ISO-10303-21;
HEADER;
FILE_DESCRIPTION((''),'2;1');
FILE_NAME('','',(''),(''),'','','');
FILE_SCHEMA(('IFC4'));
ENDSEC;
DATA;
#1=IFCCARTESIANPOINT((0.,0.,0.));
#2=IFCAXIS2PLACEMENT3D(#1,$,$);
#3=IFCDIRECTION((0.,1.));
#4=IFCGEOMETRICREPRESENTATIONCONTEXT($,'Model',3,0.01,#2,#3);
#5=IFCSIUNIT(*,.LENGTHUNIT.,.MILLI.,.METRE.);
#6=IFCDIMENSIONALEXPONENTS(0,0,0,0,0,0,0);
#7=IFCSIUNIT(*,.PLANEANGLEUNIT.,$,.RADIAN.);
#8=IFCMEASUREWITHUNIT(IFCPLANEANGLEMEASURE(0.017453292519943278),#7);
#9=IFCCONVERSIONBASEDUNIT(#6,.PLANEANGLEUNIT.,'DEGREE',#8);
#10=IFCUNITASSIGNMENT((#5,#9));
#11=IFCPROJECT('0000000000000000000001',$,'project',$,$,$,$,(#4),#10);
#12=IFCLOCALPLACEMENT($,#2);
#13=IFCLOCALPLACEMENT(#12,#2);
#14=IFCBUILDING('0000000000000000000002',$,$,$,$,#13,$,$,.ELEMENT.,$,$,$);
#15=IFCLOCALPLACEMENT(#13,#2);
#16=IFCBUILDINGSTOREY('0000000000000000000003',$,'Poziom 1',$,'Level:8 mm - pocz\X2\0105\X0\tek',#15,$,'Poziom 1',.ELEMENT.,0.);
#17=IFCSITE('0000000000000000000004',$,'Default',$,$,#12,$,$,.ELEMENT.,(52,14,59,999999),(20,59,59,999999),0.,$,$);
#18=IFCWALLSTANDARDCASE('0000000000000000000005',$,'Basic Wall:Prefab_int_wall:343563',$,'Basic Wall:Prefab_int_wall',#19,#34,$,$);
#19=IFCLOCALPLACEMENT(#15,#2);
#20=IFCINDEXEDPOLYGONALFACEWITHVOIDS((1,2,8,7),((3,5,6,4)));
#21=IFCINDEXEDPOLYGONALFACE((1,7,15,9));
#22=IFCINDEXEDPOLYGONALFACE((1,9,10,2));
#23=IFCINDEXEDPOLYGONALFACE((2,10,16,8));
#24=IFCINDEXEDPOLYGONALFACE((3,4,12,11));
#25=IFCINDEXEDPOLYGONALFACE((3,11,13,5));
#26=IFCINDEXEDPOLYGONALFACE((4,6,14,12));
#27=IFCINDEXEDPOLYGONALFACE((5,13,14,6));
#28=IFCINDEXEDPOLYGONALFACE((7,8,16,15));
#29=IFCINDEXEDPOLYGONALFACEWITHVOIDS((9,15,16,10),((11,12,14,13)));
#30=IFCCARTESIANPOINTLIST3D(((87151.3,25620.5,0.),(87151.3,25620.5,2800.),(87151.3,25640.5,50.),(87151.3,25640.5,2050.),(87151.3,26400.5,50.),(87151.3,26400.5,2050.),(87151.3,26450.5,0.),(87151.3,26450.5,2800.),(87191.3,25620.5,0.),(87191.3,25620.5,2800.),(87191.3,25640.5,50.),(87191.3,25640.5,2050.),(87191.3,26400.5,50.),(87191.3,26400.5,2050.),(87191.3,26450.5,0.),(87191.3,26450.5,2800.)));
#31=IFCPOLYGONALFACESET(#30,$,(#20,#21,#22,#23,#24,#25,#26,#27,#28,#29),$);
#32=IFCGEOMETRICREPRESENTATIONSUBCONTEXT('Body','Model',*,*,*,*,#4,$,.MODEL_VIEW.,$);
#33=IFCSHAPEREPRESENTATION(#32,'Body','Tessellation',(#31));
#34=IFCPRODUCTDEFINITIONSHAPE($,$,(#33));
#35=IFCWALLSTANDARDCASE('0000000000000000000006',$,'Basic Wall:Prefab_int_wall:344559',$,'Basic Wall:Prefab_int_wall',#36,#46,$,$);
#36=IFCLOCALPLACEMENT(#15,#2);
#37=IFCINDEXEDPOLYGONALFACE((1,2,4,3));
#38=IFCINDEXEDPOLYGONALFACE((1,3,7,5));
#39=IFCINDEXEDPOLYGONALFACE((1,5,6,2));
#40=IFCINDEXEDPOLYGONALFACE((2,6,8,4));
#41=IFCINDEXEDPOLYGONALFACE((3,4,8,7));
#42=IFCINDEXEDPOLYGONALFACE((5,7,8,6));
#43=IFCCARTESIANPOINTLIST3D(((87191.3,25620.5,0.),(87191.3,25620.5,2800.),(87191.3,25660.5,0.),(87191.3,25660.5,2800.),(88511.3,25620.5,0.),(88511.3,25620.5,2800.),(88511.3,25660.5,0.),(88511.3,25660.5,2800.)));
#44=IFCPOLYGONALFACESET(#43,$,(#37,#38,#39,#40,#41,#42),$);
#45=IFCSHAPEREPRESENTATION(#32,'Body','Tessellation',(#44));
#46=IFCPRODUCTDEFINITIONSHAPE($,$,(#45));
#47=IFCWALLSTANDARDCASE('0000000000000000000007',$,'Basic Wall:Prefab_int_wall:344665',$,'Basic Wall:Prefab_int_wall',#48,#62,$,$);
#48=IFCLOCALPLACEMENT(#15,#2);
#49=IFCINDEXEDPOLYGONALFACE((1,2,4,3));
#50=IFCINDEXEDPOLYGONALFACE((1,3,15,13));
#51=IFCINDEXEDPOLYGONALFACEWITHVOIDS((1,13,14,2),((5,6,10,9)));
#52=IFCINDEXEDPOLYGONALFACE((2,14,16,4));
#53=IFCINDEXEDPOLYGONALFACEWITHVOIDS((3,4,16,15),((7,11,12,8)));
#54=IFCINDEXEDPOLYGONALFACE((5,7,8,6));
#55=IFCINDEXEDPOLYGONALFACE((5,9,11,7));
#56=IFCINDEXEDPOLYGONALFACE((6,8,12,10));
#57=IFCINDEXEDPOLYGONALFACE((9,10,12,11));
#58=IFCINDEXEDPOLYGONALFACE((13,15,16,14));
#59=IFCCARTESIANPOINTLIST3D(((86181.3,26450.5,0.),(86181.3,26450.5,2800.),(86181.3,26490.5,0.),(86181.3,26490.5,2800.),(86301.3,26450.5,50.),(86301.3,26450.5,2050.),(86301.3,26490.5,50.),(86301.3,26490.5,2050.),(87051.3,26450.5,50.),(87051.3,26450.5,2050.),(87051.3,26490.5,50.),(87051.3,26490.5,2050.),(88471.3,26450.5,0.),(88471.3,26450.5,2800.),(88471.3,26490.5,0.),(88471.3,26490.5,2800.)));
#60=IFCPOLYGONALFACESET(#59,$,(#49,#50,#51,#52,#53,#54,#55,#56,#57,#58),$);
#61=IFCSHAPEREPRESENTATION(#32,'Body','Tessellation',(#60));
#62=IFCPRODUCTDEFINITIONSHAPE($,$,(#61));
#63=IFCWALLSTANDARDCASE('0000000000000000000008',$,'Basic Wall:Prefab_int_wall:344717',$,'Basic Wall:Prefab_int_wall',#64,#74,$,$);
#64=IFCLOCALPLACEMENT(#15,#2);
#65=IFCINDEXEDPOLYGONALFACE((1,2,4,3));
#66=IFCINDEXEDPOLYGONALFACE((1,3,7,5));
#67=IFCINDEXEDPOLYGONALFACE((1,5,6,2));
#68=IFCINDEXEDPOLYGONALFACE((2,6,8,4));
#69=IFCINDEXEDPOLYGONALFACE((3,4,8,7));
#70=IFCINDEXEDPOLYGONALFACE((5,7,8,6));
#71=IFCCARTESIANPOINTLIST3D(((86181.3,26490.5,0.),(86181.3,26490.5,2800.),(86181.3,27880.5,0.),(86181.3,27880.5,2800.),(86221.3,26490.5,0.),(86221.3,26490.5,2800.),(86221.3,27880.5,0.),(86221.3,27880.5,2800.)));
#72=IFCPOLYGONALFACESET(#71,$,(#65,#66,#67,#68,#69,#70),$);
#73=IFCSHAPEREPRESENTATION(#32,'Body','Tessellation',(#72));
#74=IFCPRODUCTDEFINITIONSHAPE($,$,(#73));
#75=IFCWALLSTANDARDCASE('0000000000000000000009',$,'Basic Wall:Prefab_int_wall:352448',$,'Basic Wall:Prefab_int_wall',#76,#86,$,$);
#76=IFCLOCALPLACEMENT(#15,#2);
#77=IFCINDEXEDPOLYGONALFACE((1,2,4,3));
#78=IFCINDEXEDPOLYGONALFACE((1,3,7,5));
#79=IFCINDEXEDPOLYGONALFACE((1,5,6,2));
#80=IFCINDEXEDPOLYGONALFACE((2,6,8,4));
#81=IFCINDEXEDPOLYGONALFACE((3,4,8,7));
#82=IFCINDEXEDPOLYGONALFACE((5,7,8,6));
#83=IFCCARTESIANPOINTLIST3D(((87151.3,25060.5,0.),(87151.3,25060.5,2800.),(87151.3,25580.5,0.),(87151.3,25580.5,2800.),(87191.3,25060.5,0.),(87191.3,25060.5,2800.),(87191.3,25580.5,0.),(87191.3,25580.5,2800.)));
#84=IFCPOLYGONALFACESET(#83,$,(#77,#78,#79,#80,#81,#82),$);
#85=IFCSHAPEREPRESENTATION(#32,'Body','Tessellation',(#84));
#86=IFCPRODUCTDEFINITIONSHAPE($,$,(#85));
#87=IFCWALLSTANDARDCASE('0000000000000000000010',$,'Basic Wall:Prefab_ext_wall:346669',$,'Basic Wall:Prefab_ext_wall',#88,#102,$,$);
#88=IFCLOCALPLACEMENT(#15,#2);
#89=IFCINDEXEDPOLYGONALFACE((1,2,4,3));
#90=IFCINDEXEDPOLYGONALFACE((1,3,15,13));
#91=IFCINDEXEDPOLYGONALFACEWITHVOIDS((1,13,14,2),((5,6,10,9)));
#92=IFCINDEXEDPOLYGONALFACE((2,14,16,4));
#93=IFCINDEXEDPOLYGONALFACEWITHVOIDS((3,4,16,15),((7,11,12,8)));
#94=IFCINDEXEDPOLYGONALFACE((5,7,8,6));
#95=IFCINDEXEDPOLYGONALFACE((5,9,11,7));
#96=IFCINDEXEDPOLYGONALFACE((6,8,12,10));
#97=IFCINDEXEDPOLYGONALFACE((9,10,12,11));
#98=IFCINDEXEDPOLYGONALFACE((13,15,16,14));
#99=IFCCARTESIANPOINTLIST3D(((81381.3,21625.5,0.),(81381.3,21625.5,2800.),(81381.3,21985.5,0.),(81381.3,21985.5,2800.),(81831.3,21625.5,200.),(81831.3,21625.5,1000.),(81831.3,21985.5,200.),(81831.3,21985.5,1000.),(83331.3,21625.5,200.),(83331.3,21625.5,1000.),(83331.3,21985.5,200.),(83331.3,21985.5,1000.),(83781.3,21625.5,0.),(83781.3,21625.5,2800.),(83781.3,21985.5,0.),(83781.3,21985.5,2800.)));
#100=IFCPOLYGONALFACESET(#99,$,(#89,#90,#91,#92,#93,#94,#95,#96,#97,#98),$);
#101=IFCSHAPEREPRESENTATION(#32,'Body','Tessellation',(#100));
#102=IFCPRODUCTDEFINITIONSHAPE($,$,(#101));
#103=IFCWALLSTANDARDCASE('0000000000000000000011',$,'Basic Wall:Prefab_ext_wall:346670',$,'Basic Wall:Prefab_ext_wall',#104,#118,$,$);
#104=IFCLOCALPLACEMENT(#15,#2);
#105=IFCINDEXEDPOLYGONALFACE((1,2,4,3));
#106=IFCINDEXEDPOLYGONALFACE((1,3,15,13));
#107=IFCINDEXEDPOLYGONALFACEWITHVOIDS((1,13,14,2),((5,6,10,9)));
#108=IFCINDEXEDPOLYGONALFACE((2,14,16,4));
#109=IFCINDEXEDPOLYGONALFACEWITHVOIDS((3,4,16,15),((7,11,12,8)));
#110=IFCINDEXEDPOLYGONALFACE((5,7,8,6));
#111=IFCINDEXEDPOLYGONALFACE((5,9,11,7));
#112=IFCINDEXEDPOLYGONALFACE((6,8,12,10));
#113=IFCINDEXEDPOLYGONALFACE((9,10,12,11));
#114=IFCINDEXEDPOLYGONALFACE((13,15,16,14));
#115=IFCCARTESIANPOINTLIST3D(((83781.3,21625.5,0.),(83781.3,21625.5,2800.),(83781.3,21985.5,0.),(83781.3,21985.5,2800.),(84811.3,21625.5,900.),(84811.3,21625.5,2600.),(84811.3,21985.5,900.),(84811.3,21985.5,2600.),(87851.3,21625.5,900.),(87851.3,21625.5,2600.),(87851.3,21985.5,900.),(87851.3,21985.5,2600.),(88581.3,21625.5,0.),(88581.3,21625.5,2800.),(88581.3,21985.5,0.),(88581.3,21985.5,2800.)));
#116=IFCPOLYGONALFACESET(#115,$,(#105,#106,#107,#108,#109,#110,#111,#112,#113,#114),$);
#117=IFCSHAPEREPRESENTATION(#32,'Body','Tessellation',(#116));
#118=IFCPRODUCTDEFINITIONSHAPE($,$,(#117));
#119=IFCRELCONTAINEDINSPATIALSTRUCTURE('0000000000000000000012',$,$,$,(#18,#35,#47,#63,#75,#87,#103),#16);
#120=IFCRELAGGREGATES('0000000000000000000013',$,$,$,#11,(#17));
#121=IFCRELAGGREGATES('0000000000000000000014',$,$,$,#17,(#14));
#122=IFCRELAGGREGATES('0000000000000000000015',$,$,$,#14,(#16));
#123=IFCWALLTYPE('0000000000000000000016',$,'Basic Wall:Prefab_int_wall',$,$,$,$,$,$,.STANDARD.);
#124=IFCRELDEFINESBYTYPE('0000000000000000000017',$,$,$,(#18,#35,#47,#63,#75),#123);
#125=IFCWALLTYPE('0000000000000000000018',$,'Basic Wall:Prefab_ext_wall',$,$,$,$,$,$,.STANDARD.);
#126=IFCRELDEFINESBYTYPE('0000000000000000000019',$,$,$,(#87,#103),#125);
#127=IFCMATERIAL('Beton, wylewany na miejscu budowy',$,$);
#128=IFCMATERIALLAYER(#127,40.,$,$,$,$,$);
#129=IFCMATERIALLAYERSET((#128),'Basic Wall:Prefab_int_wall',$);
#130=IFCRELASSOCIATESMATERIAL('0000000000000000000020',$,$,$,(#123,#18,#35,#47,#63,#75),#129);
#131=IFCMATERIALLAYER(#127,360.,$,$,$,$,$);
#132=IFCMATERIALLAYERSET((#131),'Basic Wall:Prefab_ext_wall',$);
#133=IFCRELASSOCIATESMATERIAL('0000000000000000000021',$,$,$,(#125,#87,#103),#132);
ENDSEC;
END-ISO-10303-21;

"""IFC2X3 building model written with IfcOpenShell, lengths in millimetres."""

from ifc_helpers import new_model, entity, si_unit, converted_unit, direction, frame, frame_2d, origin, origin_2d_with_axis, place, context, subcontext, project, spatial, rectangle, extrude, material, layer, layer_set, layer_usage, type_object, element, save


model = new_model("IFC2X3")

# Units and contexts
model_context = context("Model", 3, precision=0.01, world=origin(), true_north=direction((0.0, 1.0)))
body_context = subcontext(model_context, "Body", "Model", "MODEL_VIEW")
ifc_project = project(units=[si_unit("LENGTHUNIT", "METRE", prefix="MILLI"), converted_unit("PLANEANGLEUNIT", "DEGREE", entity("IfcPlaneAngleMeasure", 0.017453292519943278), si_unit("PLANEANGLEUNIT", "RADIAN"), dimensions=[0, 0, 0, 0, 0, 0, 0])], contexts=[model_context])

# Site, building, storey
site_placement = place(None, origin())
site = spatial("IfcSite", under=ifc_project, at=site_placement, Name="Default", CompositionType="ELEMENT", RefLatitude=(52, 14, 59, 999999), RefLongitude=(20, 59, 59, 999999), RefElevation=0.0)
building_placement = place(site_placement, origin())
building = spatial("IfcBuilding", under=site, at=building_placement, CompositionType="ELEMENT")
storey_placement = place(building_placement, origin())
storey = spatial("IfcBuildingStorey", under=building, at=storey_placement, Name="Poziom 1", ObjectType="Level:8 mm - początek", LongName="Poziom 1", CompositionType="ELEMENT", Elevation=0.0)

# Shared definitions
ifc_material = material(Name="Beton, wylewany na miejscu budowy")

# Shared definitions
ifc_layer_1 = layer(ifc_material, 40.0)
ifc_layer_set_1 = layer_set([ifc_layer_1], Name="Basic Wall:Prefab_int_wall")
wall_type_1 = type_object("IfcWallType", Name="Basic Wall:Prefab_int_wall", PredefinedType="STANDARD", material=ifc_layer_set_1)

# Wall, opening
ifc_layer_usage_1 = layer_usage(ifc_layer_set_1, "AXIS2", "NEGATIVE", 20.0)
wall_1_placement = place(storey_placement, frame((87171.3, 25620.5, 0.0), z_axis=(0.0, 0.0, 1.0), x_axis=(0.0, 1.0, 0.0)))
wall_1 = element("IfcWallStandardCase", 1, at=wall_1_placement, inside=storey, type_object=wall_type_1, material=ifc_layer_usage_1, Name="Basic Wall:Prefab_int_wall:343563", ObjectType="Basic Wall:Prefab_int_wall", context=body_context, shape_type="SweptSolid", body=[
    extrude(rectangle(XDim=830.0, YDim=40.0, at=frame_2d((415.0, 0.0), x_axis=(-1.0, 0.0))), origin(), (0.0, 0.0, 1.0), 2800.0),
])
opening_1_placement = place(wall_1_placement, origin())
element("IfcOpeningElement", 2, at=opening_1_placement, cuts=wall_1, ObjectType="Opening", context=body_context, shape_type="SweptSolid", body=[
    extrude(rectangle(XDim=2000.0, YDim=760.0, at=frame_2d((0.0, 0.0), x_axis=(0.0, 1.0))), frame((400.0, 20.0, 1050.0), z_axis=(0.0, -1.0, 0.0), x_axis=(-1.0, 0.0, 0.0)), (0.0, 0.0, 1.0), 40.0),
])

# Wall
ifc_layer_usage_2 = layer_usage(ifc_layer_set_1, "AXIS2", "NEGATIVE", 20.0)
wall_2_placement = place(storey_placement, frame((88511.3, 25640.5, 0.0), z_axis=(0.0, 0.0, 1.0), x_axis=(-1.0, 0.0, 0.0)))
element("IfcWallStandardCase", 3, at=wall_2_placement, inside=storey, type_object=wall_type_1, material=ifc_layer_usage_2, Name="Basic Wall:Prefab_int_wall:344559", ObjectType="Basic Wall:Prefab_int_wall", context=body_context, shape_type="SweptSolid", body=[
    extrude(rectangle(XDim=1320.0, YDim=40.0, at=frame_2d((660.0, 0.0), x_axis=(-1.0, 0.0))), origin(), (0.0, 0.0, 1.0), 2800.0),
])

# Wall, opening
ifc_layer_usage_3 = layer_usage(ifc_layer_set_1, "AXIS2", "NEGATIVE", 20.0)
wall_3_placement = place(storey_placement, frame((88471.3, 26470.5, 0.0), z_axis=(0.0, 0.0, 1.0), x_axis=(-1.0, 0.0, 0.0)))
wall_3 = element("IfcWallStandardCase", 4, at=wall_3_placement, inside=storey, type_object=wall_type_1, material=ifc_layer_usage_3, Name="Basic Wall:Prefab_int_wall:344665", ObjectType="Basic Wall:Prefab_int_wall", context=body_context, shape_type="SweptSolid", body=[
    extrude(rectangle(XDim=2290.0, YDim=40.0, at=frame_2d((1145.0, 0.0), x_axis=(-1.0, 0.0))), origin(), (0.0, 0.0, 1.0), 2800.0),
])
opening_2_placement = place(wall_3_placement, origin())
element("IfcOpeningElement", 5, at=opening_2_placement, cuts=wall_3, ObjectType="Opening", context=body_context, shape_type="SweptSolid", body=[
    extrude(rectangle(XDim=2000.0, YDim=750.0, at=frame_2d((0.0, 0.0), x_axis=(0.0, 1.0))), frame((1795.0, 20.0, 1050.0), z_axis=(0.0, -1.0, 0.0), x_axis=(-1.0, 0.0, 0.0)), (0.0, 0.0, 1.0), 40.0),
])

# Walls
ifc_layer_usage_4 = layer_usage(ifc_layer_set_1, "AXIS2", "NEGATIVE", 20.0)
wall_4_placement = place(storey_placement, frame((86201.3, 26490.5, 0.0), z_axis=(0.0, 0.0, 1.0), x_axis=(0.0, 1.0, 0.0)))
element("IfcWallStandardCase", 6, at=wall_4_placement, inside=storey, type_object=wall_type_1, material=ifc_layer_usage_4, Name="Basic Wall:Prefab_int_wall:344717", ObjectType="Basic Wall:Prefab_int_wall", context=body_context, shape_type="SweptSolid", body=[
    extrude(rectangle(XDim=1390.0, YDim=40.0, at=frame_2d((695.0, 0.0), x_axis=(-1.0, 0.0))), origin(), (0.0, 0.0, 1.0), 2800.0),
])
ifc_layer_usage_5 = layer_usage(ifc_layer_set_1, "AXIS2", "NEGATIVE", 20.0)
wall_5_placement = place(storey_placement, frame((87171.3, 25580.5, 0.0), z_axis=(0.0, 0.0, 1.0), x_axis=(0.0, -1.0, 0.0)))
element("IfcWallStandardCase", 7, at=wall_5_placement, inside=storey, type_object=wall_type_1, material=ifc_layer_usage_5, Name="Basic Wall:Prefab_int_wall:352448", ObjectType="Basic Wall:Prefab_int_wall", context=body_context, shape_type="SweptSolid", body=[
    extrude(rectangle(XDim=520.0, YDim=40.0, at=frame_2d((260.0, 0.0), x_axis=(-1.0, 0.0))), origin(), (0.0, 0.0, 1.0), 2800.0),
])

# Walls, openings
ifc_layer_2 = layer(ifc_material, 360.0)
ifc_layer_set_2 = layer_set([ifc_layer_2], Name="Basic Wall:Prefab_ext_wall")
ifc_layer_usage_6 = layer_usage(ifc_layer_set_2, "AXIS2", "NEGATIVE", 180.0)
wall_type_2 = type_object("IfcWallType", Name="Basic Wall:Prefab_ext_wall", PredefinedType="STANDARD", material=ifc_layer_set_2)
wall_6_placement = place(storey_placement, frame((81381.3, 21805.5, 0.0)))
wall_6 = element("IfcWallStandardCase", 8, at=wall_6_placement, inside=storey, type_object=wall_type_2, material=ifc_layer_usage_6, Name="Basic Wall:Prefab_ext_wall:346669", ObjectType="Basic Wall:Prefab_ext_wall", context=body_context, shape_type="SweptSolid", body=[
    extrude(rectangle(XDim=2400.0, YDim=360.0, at=frame_2d((1200.0, 0.0), x_axis=(-1.0, 0.0))), origin(), (0.0, 0.0, 1.0), 2800.0),
])
opening_3_placement = place(wall_6_placement, origin())
element("IfcOpeningElement", 9, at=opening_3_placement, cuts=wall_6, ObjectType="Opening", context=body_context, shape_type="SweptSolid", body=[
    extrude(rectangle(XDim=800.0, YDim=1500.0, at=frame_2d((0.0, 0.0), x_axis=(0.0, 1.0))), frame((1200.0, 180.0, 600.0), z_axis=(0.0, -1.0, 0.0), x_axis=(-1.0, 0.0, 0.0)), (0.0, 0.0, 1.0), 360.0),
])
ifc_layer_usage_7 = layer_usage(ifc_layer_set_2, "AXIS2", "NEGATIVE", 180.0)
wall_7_placement = place(storey_placement, frame((83781.3, 21805.5, 0.0)))
wall_7 = element("IfcWallStandardCase", 10, at=wall_7_placement, inside=storey, type_object=wall_type_2, material=ifc_layer_usage_7, Name="Basic Wall:Prefab_ext_wall:346670", ObjectType="Basic Wall:Prefab_ext_wall", context=body_context, shape_type="SweptSolid", body=[
    extrude(rectangle(XDim=4800.0, YDim=360.0, at=frame_2d((2400.0, 0.0), x_axis=(-1.0, 0.0))), origin(), (0.0, 0.0, 1.0), 2800.0),
])
opening_4_placement = place(wall_7_placement, origin())
element("IfcOpeningElement", 11, at=opening_4_placement, cuts=wall_7, ObjectType="Opening", context=body_context, shape_type="SweptSolid", body=[
    extrude(rectangle(XDim=1700.0, YDim=3040.0, at=origin_2d_with_axis()), frame((2550.0, 180.0, 1750.0), z_axis=(0.0, -1.0, 0.0), x_axis=(0.0, 0.0, 1.0)), (0.0, 0.0, 1.0), 360.0),
])

save(model, "model.ifc")
